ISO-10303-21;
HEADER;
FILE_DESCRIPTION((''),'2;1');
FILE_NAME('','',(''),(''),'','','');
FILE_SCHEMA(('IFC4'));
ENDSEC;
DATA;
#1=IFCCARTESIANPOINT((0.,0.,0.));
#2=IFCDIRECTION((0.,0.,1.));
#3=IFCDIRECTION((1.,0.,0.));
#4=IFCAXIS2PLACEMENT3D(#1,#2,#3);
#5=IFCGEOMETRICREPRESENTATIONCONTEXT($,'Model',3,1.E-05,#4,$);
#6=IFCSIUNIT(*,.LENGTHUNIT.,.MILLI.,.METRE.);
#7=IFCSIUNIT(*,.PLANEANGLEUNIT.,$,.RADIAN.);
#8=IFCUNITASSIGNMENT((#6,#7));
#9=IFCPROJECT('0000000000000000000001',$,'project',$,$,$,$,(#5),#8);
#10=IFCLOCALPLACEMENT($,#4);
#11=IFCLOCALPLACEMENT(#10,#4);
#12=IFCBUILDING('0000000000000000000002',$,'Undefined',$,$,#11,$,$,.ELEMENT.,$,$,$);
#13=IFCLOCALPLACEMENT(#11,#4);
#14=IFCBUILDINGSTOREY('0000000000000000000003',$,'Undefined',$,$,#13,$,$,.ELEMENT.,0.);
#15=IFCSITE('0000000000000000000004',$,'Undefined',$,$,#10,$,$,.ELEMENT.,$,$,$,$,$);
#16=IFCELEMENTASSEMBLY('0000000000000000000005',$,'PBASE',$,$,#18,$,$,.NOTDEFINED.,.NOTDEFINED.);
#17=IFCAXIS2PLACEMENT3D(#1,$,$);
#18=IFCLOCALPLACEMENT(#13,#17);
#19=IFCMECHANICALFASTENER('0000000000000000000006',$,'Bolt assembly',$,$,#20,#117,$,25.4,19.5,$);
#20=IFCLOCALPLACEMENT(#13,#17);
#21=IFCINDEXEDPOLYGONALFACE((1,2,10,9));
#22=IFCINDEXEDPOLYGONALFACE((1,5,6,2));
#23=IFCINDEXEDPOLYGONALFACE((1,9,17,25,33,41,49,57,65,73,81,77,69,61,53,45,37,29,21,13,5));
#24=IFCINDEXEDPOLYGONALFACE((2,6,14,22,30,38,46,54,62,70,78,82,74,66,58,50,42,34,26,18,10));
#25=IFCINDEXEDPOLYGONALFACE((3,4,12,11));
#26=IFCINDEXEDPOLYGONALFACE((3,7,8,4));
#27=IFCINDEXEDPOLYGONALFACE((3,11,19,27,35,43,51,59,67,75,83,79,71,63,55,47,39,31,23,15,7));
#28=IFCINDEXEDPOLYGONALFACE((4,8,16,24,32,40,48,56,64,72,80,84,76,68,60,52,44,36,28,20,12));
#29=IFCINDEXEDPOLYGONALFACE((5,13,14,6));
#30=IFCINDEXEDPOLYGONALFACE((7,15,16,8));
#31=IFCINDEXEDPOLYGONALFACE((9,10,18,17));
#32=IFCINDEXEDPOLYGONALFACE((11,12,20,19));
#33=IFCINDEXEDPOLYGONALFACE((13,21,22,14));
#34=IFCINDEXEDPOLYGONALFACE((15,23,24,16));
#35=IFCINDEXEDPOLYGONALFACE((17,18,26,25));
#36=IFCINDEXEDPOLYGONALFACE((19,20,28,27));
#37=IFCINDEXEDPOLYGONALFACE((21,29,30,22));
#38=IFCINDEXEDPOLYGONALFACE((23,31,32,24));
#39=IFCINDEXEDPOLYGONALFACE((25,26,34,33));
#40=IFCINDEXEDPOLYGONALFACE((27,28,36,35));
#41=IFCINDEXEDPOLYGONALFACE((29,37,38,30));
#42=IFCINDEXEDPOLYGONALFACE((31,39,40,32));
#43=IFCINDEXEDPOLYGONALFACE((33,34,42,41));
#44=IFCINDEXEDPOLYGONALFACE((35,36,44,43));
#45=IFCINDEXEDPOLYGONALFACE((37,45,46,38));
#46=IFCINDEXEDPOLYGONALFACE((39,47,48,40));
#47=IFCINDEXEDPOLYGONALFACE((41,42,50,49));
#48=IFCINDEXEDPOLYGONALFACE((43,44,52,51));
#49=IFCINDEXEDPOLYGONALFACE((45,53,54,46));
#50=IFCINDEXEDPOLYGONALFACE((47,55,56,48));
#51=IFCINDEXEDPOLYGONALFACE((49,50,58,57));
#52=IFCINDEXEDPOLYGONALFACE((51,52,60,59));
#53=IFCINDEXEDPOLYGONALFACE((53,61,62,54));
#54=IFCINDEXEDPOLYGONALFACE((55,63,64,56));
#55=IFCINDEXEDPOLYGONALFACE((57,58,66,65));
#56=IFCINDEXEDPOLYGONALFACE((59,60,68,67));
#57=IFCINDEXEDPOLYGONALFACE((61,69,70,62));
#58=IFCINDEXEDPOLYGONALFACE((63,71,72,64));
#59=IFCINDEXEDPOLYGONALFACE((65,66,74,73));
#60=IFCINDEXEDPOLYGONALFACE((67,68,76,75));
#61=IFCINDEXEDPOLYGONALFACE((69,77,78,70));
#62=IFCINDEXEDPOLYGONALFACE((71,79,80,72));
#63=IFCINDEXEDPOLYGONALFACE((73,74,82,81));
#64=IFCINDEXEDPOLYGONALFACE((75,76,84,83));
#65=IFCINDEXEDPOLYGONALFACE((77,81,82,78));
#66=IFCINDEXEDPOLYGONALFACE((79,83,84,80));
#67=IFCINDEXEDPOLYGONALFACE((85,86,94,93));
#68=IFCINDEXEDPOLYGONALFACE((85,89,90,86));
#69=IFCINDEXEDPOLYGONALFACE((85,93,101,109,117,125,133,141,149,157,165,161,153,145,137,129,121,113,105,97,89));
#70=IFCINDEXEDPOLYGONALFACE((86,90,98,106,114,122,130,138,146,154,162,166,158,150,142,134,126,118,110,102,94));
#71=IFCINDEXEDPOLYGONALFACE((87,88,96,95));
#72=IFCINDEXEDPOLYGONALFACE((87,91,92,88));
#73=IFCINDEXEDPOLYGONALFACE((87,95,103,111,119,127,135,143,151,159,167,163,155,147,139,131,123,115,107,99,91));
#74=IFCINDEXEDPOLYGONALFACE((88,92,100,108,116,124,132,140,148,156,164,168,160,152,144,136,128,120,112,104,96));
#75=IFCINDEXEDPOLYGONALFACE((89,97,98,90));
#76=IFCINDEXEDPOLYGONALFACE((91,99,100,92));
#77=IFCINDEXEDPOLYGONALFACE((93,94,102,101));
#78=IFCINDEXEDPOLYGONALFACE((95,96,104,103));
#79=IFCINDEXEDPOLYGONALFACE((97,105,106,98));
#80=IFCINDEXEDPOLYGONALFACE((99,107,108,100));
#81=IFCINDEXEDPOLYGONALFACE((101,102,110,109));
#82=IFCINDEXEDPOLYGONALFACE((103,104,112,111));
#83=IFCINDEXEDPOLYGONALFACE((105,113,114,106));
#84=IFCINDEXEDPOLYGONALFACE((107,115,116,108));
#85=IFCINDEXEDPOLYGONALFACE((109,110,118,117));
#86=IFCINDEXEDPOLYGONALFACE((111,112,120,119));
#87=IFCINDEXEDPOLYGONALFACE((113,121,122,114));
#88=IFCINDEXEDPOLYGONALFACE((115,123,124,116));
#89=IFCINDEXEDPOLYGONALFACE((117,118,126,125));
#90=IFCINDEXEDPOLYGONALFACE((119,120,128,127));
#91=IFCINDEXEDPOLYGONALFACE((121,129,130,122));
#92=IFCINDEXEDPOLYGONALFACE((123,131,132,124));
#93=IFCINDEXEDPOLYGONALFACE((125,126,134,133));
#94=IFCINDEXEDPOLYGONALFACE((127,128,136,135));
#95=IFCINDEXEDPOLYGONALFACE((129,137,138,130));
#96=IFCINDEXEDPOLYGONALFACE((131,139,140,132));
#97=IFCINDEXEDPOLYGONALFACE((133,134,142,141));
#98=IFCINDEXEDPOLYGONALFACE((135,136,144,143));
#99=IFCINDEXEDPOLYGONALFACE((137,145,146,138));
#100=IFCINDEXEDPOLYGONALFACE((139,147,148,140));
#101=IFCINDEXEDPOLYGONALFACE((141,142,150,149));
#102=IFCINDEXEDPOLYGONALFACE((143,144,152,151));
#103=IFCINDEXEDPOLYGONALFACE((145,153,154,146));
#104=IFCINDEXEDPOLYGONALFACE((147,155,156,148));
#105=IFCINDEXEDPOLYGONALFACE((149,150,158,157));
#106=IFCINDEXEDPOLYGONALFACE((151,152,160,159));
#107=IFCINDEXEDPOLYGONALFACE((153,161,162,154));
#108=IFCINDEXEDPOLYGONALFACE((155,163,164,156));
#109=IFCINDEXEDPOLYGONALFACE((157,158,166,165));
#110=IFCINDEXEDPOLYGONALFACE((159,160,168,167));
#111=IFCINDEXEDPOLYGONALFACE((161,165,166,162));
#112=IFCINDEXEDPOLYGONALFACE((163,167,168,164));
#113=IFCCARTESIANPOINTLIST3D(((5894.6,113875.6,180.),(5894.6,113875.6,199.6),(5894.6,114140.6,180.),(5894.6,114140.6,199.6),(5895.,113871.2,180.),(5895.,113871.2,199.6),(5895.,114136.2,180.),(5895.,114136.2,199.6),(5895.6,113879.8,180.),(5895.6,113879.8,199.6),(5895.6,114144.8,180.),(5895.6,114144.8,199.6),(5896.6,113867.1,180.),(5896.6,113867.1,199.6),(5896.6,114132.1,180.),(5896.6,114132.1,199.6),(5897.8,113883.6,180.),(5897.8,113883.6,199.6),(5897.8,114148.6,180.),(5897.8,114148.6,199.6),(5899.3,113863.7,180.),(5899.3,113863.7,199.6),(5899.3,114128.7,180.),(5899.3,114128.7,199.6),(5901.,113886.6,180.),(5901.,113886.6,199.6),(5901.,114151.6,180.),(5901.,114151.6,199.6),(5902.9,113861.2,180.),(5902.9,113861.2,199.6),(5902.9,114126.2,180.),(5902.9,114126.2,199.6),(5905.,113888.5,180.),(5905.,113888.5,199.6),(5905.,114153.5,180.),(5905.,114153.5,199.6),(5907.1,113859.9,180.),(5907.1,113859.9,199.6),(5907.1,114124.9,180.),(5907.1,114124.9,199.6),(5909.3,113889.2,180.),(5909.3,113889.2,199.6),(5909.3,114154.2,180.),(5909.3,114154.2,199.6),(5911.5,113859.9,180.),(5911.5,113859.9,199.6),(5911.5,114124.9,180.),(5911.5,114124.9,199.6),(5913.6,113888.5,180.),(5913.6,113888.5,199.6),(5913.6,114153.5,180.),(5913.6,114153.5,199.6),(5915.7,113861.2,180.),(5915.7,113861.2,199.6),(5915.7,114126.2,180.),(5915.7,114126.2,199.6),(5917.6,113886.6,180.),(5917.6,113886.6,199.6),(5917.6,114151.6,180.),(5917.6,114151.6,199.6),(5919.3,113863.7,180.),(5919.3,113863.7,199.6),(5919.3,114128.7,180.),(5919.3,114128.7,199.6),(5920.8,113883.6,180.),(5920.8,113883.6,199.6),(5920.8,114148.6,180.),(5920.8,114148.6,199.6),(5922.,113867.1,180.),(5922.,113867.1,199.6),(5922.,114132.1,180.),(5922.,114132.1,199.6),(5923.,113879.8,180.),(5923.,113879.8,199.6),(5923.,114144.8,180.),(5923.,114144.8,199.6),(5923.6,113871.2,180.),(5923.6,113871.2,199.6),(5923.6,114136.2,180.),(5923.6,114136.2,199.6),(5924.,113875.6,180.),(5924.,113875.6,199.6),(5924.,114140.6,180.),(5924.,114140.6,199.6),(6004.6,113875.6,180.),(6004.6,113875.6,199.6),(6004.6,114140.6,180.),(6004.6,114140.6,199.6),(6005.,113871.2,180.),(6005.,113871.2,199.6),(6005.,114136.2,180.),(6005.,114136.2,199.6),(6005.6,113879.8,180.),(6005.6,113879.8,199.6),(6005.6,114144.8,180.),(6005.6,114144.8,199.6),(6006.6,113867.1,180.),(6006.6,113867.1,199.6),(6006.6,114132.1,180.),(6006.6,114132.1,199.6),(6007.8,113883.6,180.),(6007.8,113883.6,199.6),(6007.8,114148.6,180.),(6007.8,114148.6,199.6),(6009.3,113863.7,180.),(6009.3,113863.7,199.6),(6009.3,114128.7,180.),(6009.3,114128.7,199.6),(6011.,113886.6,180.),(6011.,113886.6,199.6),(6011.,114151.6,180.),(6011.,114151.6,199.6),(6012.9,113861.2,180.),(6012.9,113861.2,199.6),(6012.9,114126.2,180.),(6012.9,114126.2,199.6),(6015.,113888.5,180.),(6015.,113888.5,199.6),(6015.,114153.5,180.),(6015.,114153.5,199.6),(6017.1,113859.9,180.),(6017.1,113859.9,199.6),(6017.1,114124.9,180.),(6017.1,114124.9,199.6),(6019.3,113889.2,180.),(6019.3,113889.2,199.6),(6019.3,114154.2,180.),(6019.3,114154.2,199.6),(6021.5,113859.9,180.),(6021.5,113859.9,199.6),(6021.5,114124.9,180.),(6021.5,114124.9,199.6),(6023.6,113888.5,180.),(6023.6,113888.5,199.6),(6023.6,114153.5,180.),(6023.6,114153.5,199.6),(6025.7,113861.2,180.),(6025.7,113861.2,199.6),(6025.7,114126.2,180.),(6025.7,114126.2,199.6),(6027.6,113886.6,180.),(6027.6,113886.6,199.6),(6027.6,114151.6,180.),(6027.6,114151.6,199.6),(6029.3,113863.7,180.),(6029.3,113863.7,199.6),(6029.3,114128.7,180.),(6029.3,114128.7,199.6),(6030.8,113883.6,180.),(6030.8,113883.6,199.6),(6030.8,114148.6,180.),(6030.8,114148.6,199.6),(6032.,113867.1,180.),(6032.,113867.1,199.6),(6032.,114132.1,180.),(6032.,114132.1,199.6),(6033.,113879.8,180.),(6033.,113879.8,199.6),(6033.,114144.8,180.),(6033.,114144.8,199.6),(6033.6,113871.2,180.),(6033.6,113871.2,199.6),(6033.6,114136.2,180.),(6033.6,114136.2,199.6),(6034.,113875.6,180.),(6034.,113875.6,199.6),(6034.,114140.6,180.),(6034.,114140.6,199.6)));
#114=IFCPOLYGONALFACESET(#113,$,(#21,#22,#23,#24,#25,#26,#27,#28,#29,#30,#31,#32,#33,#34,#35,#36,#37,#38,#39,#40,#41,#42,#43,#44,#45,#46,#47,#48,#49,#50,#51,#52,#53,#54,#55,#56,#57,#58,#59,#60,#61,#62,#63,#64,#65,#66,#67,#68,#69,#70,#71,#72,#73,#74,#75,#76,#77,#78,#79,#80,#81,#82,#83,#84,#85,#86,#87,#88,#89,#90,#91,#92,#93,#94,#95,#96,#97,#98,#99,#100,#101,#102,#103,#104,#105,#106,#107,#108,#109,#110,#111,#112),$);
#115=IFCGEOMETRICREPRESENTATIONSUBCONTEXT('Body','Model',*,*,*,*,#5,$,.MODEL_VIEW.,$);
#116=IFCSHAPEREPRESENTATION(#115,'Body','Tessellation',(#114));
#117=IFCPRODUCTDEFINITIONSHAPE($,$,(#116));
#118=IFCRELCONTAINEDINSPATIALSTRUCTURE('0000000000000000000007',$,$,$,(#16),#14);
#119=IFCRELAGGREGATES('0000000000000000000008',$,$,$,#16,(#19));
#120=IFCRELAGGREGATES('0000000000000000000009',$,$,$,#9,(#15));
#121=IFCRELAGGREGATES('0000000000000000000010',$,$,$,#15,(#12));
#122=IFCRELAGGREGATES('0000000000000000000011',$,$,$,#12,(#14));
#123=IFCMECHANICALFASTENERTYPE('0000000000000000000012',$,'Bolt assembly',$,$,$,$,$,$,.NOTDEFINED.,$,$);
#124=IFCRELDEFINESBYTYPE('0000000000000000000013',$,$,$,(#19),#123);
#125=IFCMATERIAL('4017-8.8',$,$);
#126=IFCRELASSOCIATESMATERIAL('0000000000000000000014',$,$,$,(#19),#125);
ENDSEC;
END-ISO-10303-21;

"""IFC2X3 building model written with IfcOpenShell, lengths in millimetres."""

from ifc_helpers import new_model, si_unit, frame, origin_with_axes, origin_2d_with_axis, place, context, subcontext, project, spatial, circle, extrude, source, transform, mapped, material, type_object, element, aggregate, save


model = new_model("IFC2X3")

# Units and contexts
model_context = context("Model", 3, precision=1e-05, world=origin_with_axes())
body_context = subcontext(model_context, "Body", "Model", "MODEL_VIEW")
ifc_project = project(units=[si_unit("LENGTHUNIT", "METRE", prefix="MILLI"), si_unit("PLANEANGLEUNIT", "RADIAN")], contexts=[model_context])

# Site, building, storey
site_placement = place(None, origin_with_axes())
site = spatial("IfcSite", under=ifc_project, at=site_placement, Name="Undefined", CompositionType="ELEMENT")
building_placement = place(site_placement, origin_with_axes())
building = spatial("IfcBuilding", under=site, at=building_placement, Name="Undefined", CompositionType="ELEMENT")
storey_placement = place(building_placement, origin_with_axes())
storey = spatial("IfcBuildingStorey", under=building, at=storey_placement, Name="Undefined", CompositionType="ELEMENT", Elevation=0.0)

# Element assembly
assembly_1_placement = place(storey_placement, origin_with_axes())
assembly_1 = element("IfcElementAssembly", 1, at=assembly_1_placement, inside=storey, Name="PBASE", AssemblyPlace="NOTDEFINED", PredefinedType="NOTDEFINED")

# Mechanical fastener
ifc_material_1 = material(Name="4017-8.8")
mechanical_fastener_type = type_object("IfcMechanicalFastenerType", Name="Bolt assembly")
shared_shape_1 = source(origin_with_axes(), body_context, "Body", "SweptSolid", [
    extrude(circle(Radius=14.7, at=origin_2d_with_axis()), frame((0.0, -19.5, 0.0), z_axis=(0.0, 1.0, 0.0), x_axis=(1.0, 0.0, 0.0)), (0.0, 0.0, 1.0), 19.6),
])
mechanical_fastener_1_placement = place(assembly_1_placement, frame((5964.3, 113812.5, 199.5), z_axis=(1.0, 0.0, 0.0), x_axis=(0.0, 1.0, 0.0)))
mechanical_fastener_1 = element("IfcMechanicalFastener", 2, at=mechanical_fastener_1_placement, type_object=mechanical_fastener_type, material=ifc_material_1, Name="Bolt assembly", NominalDiameter=25.4, NominalLength=19.5, context=body_context, shape_type="MappedRepresentation", body=[
    mapped(shared_shape_1, transform((62.0, 0.0, -55.0))),
    mapped(shared_shape_1, transform((62.0, 0.0, 55.0))),
    mapped(shared_shape_1, transform((327.0, 0.0, -55.0))),
    mapped(shared_shape_1, transform((327.0, 0.0, 55.0))),
])
aggregate(assembly_1, [mechanical_fastener_1])

save(model, "model.ifc")
